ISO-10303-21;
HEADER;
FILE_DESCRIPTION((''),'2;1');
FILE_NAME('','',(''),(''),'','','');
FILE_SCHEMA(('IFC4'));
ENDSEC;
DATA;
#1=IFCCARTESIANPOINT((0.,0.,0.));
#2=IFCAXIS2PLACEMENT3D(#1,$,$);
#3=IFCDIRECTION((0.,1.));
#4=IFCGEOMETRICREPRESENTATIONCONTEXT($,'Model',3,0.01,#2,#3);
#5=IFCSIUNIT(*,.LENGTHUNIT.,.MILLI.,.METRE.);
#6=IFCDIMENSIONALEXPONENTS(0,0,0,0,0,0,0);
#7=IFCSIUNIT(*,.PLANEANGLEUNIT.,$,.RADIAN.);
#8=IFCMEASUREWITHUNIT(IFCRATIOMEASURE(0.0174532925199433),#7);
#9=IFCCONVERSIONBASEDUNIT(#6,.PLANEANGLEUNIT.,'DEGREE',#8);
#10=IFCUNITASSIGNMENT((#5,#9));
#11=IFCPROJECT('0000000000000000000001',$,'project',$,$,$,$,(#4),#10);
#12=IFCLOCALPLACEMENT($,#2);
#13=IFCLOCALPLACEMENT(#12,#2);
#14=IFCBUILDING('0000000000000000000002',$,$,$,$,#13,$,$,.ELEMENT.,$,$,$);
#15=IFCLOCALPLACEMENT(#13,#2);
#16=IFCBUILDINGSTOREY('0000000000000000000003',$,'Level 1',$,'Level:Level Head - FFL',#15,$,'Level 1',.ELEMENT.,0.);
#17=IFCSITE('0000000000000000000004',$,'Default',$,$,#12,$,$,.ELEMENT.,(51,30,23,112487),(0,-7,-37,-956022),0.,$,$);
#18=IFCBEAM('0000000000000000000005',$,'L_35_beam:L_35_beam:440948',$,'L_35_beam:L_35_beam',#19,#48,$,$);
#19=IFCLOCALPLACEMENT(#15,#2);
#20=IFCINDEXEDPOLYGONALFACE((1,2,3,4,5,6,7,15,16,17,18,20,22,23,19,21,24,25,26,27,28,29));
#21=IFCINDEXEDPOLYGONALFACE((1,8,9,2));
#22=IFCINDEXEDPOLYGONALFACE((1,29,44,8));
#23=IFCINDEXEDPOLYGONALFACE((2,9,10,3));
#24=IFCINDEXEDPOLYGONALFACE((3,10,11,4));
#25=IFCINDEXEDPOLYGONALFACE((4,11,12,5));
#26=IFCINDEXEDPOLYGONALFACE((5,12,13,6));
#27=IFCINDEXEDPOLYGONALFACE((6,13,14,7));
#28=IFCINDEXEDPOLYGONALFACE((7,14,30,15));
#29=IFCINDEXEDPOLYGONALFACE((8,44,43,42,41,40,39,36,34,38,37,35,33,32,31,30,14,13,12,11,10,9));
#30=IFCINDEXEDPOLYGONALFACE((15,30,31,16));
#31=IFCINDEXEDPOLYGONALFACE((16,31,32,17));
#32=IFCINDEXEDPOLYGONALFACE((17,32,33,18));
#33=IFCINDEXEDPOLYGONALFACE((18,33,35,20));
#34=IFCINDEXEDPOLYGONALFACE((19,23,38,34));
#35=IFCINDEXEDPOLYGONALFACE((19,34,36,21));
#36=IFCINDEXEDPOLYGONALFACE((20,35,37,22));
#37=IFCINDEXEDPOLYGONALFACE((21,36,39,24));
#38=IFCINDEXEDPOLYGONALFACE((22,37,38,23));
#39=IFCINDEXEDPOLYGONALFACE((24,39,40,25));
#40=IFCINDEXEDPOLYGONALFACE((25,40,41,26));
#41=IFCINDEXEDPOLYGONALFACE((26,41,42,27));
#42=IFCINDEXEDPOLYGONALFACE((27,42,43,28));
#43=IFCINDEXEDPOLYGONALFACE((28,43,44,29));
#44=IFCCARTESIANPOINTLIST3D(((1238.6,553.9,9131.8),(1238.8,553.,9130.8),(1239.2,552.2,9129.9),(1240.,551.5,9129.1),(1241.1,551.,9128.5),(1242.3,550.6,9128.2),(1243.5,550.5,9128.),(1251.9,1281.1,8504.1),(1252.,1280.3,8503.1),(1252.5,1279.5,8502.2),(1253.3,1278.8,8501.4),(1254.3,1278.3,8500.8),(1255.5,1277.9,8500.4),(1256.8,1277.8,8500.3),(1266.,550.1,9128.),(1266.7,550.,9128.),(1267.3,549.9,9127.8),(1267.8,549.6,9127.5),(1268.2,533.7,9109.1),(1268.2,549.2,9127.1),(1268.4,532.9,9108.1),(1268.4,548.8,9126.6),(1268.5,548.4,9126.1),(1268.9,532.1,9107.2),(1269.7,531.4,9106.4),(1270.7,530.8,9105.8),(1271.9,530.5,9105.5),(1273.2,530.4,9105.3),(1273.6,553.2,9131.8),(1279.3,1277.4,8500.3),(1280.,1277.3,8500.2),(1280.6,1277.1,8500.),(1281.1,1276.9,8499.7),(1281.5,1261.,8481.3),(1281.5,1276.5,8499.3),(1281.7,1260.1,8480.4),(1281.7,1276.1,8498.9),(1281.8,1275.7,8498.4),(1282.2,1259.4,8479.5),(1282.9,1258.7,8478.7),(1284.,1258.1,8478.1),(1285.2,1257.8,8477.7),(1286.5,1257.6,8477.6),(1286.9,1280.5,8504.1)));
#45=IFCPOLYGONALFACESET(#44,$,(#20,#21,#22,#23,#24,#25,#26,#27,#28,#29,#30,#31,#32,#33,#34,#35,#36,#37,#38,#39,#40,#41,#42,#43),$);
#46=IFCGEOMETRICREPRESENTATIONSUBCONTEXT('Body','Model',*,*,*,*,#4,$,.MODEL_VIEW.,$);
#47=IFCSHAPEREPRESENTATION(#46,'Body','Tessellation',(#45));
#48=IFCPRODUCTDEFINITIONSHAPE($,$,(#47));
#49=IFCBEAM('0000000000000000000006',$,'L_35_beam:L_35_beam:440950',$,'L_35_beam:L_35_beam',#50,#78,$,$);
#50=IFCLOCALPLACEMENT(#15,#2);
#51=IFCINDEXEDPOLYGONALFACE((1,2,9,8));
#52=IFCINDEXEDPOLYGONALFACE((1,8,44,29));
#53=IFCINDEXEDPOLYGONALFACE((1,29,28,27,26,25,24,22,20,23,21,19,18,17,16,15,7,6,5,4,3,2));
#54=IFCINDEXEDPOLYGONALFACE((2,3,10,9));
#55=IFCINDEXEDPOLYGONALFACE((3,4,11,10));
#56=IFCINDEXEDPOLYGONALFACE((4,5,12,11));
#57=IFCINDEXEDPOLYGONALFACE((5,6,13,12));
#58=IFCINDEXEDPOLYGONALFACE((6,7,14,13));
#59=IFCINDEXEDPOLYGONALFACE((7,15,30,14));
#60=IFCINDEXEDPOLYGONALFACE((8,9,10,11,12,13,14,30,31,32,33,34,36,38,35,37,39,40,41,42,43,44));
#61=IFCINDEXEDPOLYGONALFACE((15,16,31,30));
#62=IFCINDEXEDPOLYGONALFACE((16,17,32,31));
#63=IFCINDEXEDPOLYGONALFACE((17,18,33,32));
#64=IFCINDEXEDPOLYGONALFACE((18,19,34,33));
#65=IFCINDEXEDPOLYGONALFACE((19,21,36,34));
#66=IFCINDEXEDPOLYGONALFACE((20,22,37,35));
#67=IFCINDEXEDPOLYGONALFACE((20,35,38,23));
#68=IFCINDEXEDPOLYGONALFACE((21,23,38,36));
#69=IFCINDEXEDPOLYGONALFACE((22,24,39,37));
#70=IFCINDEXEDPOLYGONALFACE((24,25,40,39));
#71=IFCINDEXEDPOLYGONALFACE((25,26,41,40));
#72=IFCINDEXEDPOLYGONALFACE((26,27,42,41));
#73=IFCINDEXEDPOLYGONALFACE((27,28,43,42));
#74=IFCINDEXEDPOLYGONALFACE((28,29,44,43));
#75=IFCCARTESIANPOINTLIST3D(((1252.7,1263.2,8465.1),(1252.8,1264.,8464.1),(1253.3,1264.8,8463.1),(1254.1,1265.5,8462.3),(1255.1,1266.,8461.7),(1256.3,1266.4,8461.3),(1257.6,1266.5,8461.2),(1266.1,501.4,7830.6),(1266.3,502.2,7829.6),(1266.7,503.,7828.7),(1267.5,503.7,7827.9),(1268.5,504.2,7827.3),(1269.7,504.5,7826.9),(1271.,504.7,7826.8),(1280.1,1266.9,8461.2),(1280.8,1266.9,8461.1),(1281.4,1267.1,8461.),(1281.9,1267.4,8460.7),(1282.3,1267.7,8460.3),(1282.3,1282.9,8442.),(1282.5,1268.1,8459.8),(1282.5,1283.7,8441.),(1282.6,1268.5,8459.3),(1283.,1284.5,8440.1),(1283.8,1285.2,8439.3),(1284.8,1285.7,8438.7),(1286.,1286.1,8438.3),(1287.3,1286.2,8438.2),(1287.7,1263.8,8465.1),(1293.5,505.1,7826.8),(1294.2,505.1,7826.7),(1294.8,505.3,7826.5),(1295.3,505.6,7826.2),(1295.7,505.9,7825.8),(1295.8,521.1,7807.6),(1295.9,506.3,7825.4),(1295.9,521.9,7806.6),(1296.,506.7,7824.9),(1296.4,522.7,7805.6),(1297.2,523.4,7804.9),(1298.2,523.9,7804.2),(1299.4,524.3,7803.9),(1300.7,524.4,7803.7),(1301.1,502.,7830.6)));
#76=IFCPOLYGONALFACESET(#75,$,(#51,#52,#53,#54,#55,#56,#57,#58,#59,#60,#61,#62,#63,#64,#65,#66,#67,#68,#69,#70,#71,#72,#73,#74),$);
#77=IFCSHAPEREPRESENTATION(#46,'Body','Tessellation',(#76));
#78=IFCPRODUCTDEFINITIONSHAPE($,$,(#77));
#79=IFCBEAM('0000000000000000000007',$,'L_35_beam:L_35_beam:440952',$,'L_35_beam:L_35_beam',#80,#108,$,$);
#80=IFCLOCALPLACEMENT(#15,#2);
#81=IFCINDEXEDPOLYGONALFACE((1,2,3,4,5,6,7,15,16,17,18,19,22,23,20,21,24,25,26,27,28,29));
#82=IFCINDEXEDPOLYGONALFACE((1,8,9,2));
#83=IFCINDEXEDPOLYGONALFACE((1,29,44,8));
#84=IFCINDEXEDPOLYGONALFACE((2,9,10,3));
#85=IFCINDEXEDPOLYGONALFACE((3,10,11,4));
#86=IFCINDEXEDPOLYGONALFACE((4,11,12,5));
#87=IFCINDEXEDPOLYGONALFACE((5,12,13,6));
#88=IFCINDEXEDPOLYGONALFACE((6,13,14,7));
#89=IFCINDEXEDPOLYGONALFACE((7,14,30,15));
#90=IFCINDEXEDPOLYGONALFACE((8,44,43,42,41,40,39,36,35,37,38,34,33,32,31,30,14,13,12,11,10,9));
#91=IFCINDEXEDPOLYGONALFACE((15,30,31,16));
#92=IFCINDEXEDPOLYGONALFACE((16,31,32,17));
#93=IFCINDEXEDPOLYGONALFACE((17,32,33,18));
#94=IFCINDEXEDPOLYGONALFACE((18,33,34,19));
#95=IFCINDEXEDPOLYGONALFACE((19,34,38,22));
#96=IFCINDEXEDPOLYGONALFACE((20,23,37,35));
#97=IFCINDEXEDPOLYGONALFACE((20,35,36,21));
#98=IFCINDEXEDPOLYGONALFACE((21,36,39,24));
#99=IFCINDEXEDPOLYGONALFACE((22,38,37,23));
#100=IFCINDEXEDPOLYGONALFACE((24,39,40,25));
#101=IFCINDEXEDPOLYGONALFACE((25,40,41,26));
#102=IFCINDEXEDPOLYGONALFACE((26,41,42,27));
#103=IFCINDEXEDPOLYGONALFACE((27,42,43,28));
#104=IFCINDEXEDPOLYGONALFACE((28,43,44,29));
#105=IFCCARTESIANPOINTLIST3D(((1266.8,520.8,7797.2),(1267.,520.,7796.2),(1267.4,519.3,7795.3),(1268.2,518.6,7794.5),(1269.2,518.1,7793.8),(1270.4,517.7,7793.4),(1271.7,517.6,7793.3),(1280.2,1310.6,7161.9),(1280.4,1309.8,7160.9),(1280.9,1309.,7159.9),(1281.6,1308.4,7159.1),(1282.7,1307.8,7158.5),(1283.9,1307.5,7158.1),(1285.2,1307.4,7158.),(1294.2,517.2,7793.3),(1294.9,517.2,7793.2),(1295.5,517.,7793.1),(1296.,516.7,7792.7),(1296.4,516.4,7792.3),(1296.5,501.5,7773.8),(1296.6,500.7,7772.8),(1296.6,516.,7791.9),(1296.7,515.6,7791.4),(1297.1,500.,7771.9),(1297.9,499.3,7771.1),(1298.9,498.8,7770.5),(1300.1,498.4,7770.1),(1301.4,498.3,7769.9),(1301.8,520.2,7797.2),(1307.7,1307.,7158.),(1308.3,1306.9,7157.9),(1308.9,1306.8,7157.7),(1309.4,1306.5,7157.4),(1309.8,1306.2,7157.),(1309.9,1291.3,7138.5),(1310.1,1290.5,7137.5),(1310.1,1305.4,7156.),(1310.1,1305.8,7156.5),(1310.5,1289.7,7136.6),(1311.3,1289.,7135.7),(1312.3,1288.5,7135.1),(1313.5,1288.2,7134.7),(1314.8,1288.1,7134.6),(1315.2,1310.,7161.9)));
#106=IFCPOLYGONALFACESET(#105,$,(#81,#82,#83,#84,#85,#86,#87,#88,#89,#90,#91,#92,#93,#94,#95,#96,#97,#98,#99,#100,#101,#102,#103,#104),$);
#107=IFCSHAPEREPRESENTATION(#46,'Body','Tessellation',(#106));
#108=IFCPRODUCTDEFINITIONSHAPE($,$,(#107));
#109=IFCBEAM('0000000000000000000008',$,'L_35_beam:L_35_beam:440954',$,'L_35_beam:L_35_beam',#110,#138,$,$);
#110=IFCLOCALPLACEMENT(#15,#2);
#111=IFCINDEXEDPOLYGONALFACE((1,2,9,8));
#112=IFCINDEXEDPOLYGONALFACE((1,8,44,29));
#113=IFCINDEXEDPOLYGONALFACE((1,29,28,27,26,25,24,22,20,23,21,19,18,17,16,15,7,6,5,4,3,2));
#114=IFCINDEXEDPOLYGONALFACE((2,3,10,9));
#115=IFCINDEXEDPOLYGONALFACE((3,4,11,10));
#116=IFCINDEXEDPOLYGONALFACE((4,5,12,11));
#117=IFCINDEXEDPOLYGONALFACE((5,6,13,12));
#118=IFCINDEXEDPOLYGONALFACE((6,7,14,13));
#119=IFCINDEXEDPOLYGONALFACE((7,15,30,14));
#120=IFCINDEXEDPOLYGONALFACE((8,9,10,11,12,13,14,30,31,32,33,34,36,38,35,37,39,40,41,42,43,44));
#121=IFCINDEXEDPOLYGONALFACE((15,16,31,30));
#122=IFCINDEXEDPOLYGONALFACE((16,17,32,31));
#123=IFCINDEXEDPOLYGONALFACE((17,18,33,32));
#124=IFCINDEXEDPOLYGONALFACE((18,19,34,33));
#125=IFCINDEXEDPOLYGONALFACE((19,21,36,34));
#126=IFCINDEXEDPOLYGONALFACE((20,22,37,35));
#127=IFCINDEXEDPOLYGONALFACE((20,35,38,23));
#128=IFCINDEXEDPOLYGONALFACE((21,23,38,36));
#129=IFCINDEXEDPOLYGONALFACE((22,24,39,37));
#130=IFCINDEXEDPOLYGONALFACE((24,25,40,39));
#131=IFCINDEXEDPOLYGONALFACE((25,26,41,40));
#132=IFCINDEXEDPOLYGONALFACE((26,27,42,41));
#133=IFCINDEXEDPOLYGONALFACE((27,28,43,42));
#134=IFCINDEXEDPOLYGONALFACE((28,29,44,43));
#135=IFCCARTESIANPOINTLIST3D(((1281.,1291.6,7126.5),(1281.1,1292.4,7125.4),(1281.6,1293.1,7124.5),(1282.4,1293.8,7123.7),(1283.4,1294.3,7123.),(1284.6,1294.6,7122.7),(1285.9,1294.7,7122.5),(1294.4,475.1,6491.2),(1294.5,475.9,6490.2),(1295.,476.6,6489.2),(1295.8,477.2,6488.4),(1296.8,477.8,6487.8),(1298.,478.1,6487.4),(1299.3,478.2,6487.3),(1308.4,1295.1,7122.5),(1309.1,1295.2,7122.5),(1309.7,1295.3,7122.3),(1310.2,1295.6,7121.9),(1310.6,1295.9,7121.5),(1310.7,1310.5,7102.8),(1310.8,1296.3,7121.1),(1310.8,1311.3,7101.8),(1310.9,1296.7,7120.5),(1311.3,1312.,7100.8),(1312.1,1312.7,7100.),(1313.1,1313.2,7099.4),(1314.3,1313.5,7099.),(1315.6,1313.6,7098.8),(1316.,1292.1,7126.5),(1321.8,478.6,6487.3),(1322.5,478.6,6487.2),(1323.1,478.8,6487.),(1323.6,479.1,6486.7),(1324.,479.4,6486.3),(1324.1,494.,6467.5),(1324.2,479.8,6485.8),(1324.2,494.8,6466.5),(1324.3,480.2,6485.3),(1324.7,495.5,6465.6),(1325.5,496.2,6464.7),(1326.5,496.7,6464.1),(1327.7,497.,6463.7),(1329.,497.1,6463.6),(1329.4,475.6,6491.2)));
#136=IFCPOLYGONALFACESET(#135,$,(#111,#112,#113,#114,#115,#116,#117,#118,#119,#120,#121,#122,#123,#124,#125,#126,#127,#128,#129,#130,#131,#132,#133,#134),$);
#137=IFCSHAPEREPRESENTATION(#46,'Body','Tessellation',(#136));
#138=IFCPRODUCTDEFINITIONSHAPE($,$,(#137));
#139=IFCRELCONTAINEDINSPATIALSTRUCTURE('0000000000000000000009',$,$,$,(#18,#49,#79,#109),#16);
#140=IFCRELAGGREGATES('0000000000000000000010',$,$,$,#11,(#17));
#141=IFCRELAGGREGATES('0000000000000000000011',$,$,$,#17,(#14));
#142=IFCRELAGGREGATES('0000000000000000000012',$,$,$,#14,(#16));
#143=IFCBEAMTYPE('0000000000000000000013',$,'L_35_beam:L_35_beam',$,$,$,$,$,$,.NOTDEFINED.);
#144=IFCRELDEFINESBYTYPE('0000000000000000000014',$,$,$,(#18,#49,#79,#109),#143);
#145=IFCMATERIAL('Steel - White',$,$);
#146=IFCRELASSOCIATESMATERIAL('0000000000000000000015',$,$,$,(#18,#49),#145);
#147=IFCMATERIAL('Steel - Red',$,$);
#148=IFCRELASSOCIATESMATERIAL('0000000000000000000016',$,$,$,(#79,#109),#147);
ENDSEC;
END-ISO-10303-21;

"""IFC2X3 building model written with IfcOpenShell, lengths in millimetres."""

from ifc_helpers import new_model, entity, si_unit, converted_unit, direction, frame, frame_2d, origin, place, context, subcontext, project, spatial, polyline, circle_curve, parameter, trimmed, segment, composite_curve, outline, extrude, material, type_object, element, save


model = new_model("IFC2X3")

# Units and contexts
model_context = context("Model", 3, precision=0.01, world=origin(), true_north=direction((0.0, 1.0)))
body_context = subcontext(model_context, "Body", "Model", "MODEL_VIEW")
ifc_project = project(units=[si_unit("LENGTHUNIT", "METRE", prefix="MILLI"), converted_unit("PLANEANGLEUNIT", "DEGREE", entity("IfcRatioMeasure", 0.0174532925199433), si_unit("PLANEANGLEUNIT", "RADIAN"), dimensions=[0, 0, 0, 0, 0, 0, 0])], contexts=[model_context])

# Site, building, storey
site_placement = place(None, origin())
site = spatial("IfcSite", under=ifc_project, at=site_placement, Name="Default", CompositionType="ELEMENT", RefLatitude=(51, 30, 23, 112487), RefLongitude=(0, -7, -37, -956022), RefElevation=0.0)
building_placement = place(site_placement, origin())
building = spatial("IfcBuilding", under=site, at=building_placement, CompositionType="ELEMENT")
storey_placement = place(building_placement, origin())
storey = spatial("IfcBuildingStorey", under=building, at=storey_placement, Name="Level 1", ObjectType="Level:Level Head - FFL", LongName="Level 1", CompositionType="ELEMENT", Elevation=0.0)

# Beams
ifc_material_1 = material(Name="Steel - Red")
ifc_material_2 = material(Name="Steel - White")
beam_type_1 = type_object("IfcBeamType", Name="L_35_beam:L_35_beam", PredefinedType="NOTDEFINED")
beam_1_placement = place(storey_placement, frame((1295.1, 1295.1, 8468.2), z_axis=(0.011914, 0.653245, 0.757053), x_axis=(-0.013805, -0.756927, 0.653353)))
element("IfcBeam", 1, at=beam_1_placement, inside=storey, type_object=beam_type_1, material=ifc_material_2, Name="L_35_beam:L_35_beam:440948", ObjectType="L_35_beam:L_35_beam", context=body_context, shape_type="SweptSolid", body=[
    extrude(outline(composite_curve([segment(polyline([(-23.2, -11.8), (11.8, -11.8)]), True, "CONTINUOUS"), segment(polyline([(11.8, -11.8), (11.8, 23.2)]), True, "CONTINUOUS"), segment(trimmed(circle_curve(frame_2d((11.8, 18.2), x_axis=(0.0, 1.0)), 5.0), [parameter(0.0)], [parameter(90.0)], True, "PARAMETER"), True, "CONTINUOUS"), segment(polyline([(6.8, 18.2), (6.8, -4.3)]), True, "CONTINUOUS"), segment(trimmed(circle_curve(frame_2d((4.3, -4.3), x_axis=(1.0, 0.0)), 2.5), [parameter(270.0)], [parameter(0.0)], True, "PARAMETER"), False, "CONTINUOUS"), segment(polyline([(4.3, -6.8), (-18.2, -6.8)]), True, "CONTINUOUS"), segment(trimmed(circle_curve(frame_2d((-18.2, -11.8), x_axis=(0.0, 1.0)), 5.0), [parameter(0.0)], [parameter(90.0)], True, "PARAMETER"), True, "CONTINUOUS")], self_intersect=False)), frame((34.6, -19.8, 5.7), z_axis=(1.0, 0.0, 0.0), x_axis=(0.0, 0.0, 1.0)), (0.0, 0.0, 1.0), 960.8),
])
beam_2_placement = place(storey_placement, frame((1295.1, 1295.1, 8468.2), z_axis=(0.011258, -0.639777, 0.768478), x_axis=(0.01352, -0.768359, -0.639876)))
element("IfcBeam", 2, at=beam_2_placement, inside=storey, type_object=beam_type_1, material=ifc_material_2, Name="L_35_beam:L_35_beam:440950", ObjectType="L_35_beam:L_35_beam", context=body_context, shape_type="SweptSolid", body=[
    extrude(outline(composite_curve([segment(polyline([(-23.2, -11.8), (11.8, -11.8)]), True, "CONTINUOUS"), segment(polyline([(11.8, -11.8), (11.8, 23.2)]), True, "CONTINUOUS"), segment(trimmed(circle_curve(frame_2d((11.8, 18.2), x_axis=(0.0, 1.0)), 5.0), [parameter(0.0)], [parameter(90.0)], True, "PARAMETER"), True, "CONTINUOUS"), segment(polyline([(6.8, 18.2), (6.8, -4.3)]), True, "CONTINUOUS"), segment(trimmed(circle_curve(frame_2d((4.3, -4.3), x_axis=(1.0, 0.0)), 2.5), [parameter(270.0)], [parameter(0.0)], True, "PARAMETER"), False, "CONTINUOUS"), segment(polyline([(4.3, -6.8), (-18.2, -6.8)]), True, "CONTINUOUS"), segment(trimmed(circle_curve(frame_2d((-18.2, -11.8), x_axis=(0.0, 1.0)), 5.0), [parameter(0.0)], [parameter(90.0)], True, "PARAMETER"), True, "CONTINUOUS")], self_intersect=False)), frame((26.0, -19.8, 5.7), z_axis=(1.0, 0.0, 0.0), x_axis=(0.0, 0.0, 1.0)), (0.0, 0.0, 1.0), 991.5),
])
beam_3_placement = place(storey_placement, frame((1323.4, 1323.4, 7128.5), z_axis=(0.010652, 0.626668, 0.779213), x_axis=(-0.013243, -0.779101, 0.626759)))
element("IfcBeam", 3, at=beam_3_placement, inside=storey, type_object=beam_type_1, material=ifc_material_1, Name="L_35_beam:L_35_beam:440952", ObjectType="L_35_beam:L_35_beam", context=body_context, shape_type="SweptSolid", body=[
    extrude(outline(composite_curve([segment(polyline([(-23.2, -11.8), (11.8, -11.8)]), True, "CONTINUOUS"), segment(polyline([(11.8, -11.8), (11.8, 23.2)]), True, "CONTINUOUS"), segment(trimmed(circle_curve(frame_2d((11.8, 18.2), x_axis=(0.0, 1.0)), 5.0), [parameter(0.0)], [parameter(90.0)], True, "PARAMETER"), True, "CONTINUOUS"), segment(polyline([(6.8, 18.2), (6.8, -4.3)]), True, "CONTINUOUS"), segment(trimmed(circle_curve(frame_2d((4.3, -4.3), x_axis=(1.0, 0.0)), 2.5), [parameter(270.0)], [parameter(0.0)], True, "PARAMETER"), False, "CONTINUOUS"), segment(polyline([(4.3, -6.8), (-18.2, -6.8)]), True, "CONTINUOUS"), segment(trimmed(circle_curve(frame_2d((-18.2, -11.8), x_axis=(0.0, 1.0)), 5.0), [parameter(0.0)], [parameter(90.0)], True, "PARAMETER"), True, "CONTINUOUS")], self_intersect=False)), frame((31.5, -19.8, 5.7), z_axis=(1.0, 0.0, 0.0), x_axis=(0.0, 0.0, 1.0)), (0.0, 0.0, 1.0), 1013.7),
])
beam_4_placement = place(storey_placement, frame((1323.4, 1323.4, 7128.5), z_axis=(0.010092, -0.61392, 0.789304), x_axis=(0.012974, -0.789197, -0.614003)))
element("IfcBeam", 4, at=beam_4_placement, inside=storey, type_object=beam_type_1, material=ifc_material_1, Name="L_35_beam:L_35_beam:440954", ObjectType="L_35_beam:L_35_beam", context=body_context, shape_type="SweptSolid", body=[
    extrude(outline(composite_curve([segment(polyline([(-23.2, -11.8), (11.8, -11.8)]), True, "CONTINUOUS"), segment(polyline([(11.8, -11.8), (11.8, 23.2)]), True, "CONTINUOUS"), segment(trimmed(circle_curve(frame_2d((11.8, 18.2), x_axis=(0.0, 1.0)), 5.0), [parameter(0.0)], [parameter(90.0)], True, "PARAMETER"), True, "CONTINUOUS"), segment(polyline([(6.8, 18.2), (6.8, -4.3)]), True, "CONTINUOUS"), segment(trimmed(circle_curve(frame_2d((4.3, -4.3), x_axis=(1.0, 0.0)), 2.5), [parameter(270.0)], [parameter(0.0)], True, "PARAMETER"), False, "CONTINUOUS"), segment(polyline([(4.3, -6.8), (-18.2, -6.8)]), True, "CONTINUOUS"), segment(trimmed(circle_curve(frame_2d((-18.2, -11.8), x_axis=(0.0, 1.0)), 5.0), [parameter(0.0)], [parameter(90.0)], True, "PARAMETER"), True, "CONTINUOUS")], self_intersect=False)), frame((25.8, -19.8, 5.7), z_axis=(1.0, 0.0, 0.0), x_axis=(0.0, 0.0, 1.0)), (0.0, 0.0, 1.0), 1034.6),
])

save(model, "model.ifc")
